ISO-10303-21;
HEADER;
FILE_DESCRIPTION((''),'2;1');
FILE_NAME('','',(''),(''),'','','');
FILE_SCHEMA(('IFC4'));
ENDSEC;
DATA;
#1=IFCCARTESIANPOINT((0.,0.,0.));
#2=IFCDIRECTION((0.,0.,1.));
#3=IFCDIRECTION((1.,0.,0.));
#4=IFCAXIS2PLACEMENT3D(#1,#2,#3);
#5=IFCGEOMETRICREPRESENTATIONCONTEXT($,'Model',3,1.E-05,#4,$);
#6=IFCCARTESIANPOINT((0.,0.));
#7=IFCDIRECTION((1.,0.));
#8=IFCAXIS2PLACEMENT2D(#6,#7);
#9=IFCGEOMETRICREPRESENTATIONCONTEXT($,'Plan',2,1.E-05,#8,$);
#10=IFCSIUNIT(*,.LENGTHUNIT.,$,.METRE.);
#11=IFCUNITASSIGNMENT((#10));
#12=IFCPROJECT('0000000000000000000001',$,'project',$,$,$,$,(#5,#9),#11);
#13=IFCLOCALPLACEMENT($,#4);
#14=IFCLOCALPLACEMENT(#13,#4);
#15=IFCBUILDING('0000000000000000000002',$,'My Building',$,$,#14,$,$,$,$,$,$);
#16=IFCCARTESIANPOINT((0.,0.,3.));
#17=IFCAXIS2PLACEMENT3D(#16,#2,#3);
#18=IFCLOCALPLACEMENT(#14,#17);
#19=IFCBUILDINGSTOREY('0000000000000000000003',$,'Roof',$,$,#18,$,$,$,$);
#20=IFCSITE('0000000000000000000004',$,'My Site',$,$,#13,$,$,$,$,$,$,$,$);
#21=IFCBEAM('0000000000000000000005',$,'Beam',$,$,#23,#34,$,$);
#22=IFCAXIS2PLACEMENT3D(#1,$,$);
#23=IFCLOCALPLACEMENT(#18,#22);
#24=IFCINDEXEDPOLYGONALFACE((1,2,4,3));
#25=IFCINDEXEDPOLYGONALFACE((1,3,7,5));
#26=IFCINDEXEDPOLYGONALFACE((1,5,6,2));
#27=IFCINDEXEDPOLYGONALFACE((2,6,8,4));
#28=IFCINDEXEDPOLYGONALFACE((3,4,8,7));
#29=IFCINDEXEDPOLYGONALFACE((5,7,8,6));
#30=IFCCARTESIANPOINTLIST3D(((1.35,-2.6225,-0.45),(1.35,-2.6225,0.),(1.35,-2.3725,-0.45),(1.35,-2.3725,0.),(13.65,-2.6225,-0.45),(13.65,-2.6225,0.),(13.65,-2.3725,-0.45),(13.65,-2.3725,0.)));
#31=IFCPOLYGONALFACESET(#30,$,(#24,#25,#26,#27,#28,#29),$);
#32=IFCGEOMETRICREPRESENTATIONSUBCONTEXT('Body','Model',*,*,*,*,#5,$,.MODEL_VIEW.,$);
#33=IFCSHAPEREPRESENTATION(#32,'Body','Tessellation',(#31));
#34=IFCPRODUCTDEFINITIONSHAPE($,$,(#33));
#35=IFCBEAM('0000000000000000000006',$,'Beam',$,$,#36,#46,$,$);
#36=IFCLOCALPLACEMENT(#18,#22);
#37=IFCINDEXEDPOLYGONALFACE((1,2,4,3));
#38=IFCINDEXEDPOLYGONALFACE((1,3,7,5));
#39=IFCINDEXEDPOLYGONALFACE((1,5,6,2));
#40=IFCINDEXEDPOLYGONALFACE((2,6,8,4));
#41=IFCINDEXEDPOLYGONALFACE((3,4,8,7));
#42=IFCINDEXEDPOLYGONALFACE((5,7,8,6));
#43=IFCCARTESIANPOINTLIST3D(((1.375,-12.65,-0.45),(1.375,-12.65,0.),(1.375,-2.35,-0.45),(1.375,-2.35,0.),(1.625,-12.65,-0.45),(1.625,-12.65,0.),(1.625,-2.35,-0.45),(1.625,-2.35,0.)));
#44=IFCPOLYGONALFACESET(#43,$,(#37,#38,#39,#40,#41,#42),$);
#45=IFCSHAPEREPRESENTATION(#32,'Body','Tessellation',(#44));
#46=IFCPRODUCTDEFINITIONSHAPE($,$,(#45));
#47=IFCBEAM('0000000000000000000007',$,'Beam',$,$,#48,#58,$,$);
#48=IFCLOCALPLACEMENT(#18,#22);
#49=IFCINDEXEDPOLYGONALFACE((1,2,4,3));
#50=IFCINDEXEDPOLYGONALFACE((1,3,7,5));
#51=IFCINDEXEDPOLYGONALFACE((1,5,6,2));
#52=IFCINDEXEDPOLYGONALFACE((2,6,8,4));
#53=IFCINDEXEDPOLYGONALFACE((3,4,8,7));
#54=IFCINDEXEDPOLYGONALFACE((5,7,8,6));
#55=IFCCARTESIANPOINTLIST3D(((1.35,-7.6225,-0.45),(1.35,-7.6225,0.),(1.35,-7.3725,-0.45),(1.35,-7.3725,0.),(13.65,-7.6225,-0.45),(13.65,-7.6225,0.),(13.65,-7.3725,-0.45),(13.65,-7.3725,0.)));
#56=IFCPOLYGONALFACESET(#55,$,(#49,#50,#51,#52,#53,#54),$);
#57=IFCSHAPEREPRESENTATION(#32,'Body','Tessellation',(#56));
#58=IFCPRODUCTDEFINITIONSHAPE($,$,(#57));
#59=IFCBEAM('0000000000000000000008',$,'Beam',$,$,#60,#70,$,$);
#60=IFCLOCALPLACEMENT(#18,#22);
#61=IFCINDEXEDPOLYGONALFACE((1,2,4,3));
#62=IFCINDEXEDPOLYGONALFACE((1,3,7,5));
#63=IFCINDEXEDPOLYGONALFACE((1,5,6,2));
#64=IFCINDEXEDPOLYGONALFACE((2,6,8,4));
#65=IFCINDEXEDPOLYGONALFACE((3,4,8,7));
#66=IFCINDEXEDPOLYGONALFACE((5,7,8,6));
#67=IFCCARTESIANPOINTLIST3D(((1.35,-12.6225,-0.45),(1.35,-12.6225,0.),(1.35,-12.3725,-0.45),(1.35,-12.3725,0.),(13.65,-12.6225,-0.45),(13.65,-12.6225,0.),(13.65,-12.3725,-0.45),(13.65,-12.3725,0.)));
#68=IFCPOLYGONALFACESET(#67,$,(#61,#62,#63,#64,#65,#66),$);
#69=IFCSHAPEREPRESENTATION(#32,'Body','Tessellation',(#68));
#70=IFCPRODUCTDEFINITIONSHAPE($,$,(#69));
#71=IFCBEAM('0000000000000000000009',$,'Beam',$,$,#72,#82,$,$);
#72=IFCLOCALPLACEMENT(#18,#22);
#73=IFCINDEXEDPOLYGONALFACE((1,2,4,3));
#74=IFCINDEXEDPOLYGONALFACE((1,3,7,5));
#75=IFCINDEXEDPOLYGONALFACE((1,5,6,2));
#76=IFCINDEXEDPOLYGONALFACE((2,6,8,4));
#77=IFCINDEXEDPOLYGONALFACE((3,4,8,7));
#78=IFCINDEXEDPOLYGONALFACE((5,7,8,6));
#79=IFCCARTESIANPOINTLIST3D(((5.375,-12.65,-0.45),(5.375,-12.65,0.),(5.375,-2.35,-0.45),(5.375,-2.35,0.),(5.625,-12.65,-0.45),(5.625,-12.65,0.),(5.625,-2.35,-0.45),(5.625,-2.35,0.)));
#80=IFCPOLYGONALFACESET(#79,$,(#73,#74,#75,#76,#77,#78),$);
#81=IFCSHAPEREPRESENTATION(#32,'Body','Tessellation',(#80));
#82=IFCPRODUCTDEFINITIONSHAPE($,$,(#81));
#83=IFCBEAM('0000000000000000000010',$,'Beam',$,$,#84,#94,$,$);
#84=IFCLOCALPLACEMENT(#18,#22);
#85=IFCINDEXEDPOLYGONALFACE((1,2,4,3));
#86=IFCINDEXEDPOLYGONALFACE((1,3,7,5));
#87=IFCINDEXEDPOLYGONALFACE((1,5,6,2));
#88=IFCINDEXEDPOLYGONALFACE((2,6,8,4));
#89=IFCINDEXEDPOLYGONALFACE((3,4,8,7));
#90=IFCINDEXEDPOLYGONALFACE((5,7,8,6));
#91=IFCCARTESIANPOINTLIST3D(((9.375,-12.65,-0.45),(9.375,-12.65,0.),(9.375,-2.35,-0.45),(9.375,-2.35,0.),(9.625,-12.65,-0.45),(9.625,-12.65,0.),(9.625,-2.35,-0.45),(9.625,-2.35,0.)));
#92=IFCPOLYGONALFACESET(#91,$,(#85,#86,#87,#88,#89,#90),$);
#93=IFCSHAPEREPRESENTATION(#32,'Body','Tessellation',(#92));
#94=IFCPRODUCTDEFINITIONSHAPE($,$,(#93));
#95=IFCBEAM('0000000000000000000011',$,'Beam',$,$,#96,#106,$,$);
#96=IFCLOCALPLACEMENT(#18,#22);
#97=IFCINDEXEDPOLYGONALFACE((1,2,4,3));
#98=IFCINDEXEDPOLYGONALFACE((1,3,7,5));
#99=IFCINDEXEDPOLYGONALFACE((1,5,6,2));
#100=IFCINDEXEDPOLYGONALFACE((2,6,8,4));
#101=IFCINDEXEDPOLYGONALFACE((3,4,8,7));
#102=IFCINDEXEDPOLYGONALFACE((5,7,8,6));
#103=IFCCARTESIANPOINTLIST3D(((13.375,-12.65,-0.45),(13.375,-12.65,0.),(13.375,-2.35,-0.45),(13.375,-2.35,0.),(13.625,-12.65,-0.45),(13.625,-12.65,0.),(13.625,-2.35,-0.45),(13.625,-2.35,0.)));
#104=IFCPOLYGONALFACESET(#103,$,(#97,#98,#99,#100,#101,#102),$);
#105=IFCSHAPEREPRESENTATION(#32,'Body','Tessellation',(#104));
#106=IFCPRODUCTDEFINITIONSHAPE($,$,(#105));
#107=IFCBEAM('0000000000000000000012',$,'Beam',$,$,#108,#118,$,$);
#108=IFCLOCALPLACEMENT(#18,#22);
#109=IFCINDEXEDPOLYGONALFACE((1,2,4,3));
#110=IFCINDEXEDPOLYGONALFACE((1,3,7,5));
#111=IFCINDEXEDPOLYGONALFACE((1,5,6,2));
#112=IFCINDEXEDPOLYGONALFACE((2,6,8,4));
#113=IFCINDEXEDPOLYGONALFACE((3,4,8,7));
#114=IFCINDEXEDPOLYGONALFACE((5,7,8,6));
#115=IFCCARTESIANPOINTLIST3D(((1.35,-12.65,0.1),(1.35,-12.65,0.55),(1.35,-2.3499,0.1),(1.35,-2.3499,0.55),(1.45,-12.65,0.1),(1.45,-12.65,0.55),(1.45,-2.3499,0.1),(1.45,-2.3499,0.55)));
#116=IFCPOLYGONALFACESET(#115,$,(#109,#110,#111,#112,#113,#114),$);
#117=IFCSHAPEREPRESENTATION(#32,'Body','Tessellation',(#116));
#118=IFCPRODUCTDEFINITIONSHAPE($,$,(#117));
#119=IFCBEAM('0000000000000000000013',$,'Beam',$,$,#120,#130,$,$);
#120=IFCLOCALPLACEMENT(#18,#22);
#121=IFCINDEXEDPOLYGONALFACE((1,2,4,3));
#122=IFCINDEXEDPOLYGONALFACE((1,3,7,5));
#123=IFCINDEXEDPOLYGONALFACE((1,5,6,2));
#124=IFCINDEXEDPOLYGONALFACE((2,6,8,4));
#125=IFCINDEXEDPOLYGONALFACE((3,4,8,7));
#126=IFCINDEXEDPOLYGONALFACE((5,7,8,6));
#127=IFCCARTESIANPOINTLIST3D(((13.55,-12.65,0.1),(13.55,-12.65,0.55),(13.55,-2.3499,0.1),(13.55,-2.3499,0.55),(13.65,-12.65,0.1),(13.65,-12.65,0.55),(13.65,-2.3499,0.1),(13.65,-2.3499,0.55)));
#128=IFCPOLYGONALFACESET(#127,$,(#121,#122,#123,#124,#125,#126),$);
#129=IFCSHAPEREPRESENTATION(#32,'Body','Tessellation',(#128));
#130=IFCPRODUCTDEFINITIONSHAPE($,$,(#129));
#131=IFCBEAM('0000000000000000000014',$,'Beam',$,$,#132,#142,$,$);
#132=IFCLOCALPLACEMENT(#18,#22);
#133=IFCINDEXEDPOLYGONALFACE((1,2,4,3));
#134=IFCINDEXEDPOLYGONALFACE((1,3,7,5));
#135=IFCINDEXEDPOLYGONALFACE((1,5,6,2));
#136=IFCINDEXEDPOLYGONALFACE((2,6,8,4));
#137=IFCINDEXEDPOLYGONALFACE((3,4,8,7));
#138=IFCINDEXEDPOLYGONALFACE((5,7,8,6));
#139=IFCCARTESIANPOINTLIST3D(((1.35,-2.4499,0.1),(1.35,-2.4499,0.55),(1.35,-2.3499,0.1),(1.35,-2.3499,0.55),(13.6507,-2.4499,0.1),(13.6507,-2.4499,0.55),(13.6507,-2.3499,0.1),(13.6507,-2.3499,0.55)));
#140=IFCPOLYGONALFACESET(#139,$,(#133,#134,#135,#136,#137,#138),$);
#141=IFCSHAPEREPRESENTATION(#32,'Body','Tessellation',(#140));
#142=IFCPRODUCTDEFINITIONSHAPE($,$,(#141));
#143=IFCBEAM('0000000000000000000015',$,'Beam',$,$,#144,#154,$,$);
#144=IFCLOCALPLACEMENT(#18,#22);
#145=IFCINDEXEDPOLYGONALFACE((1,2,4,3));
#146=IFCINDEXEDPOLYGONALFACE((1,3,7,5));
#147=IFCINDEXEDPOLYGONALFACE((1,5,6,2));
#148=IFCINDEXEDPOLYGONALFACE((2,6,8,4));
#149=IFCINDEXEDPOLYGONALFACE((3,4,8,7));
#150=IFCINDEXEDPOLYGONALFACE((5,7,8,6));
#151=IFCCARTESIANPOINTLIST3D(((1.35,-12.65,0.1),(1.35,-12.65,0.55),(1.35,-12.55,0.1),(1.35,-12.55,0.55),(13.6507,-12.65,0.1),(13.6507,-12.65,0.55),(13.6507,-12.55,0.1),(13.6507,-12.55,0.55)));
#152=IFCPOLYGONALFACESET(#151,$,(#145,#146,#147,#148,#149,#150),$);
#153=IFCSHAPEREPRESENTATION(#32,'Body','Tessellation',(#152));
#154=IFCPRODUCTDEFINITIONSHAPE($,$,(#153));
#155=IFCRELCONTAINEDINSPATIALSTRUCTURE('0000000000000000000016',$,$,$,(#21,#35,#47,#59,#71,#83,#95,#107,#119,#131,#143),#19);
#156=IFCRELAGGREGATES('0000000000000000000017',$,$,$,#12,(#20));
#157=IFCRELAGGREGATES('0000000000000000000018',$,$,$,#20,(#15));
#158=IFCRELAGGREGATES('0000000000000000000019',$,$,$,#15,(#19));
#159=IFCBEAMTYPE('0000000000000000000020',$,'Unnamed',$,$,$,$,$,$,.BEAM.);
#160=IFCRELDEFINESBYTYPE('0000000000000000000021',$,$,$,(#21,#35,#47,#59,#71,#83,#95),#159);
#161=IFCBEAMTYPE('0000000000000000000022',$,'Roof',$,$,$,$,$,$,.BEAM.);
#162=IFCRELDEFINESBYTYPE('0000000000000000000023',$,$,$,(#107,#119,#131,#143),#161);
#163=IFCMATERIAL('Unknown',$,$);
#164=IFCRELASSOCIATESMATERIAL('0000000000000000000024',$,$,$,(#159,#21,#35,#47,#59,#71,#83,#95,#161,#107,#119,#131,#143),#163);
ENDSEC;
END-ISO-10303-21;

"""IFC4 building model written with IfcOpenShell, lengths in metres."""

from ifc_helpers import new_model, si_unit, frame, origin_with_axes, origin_2d_with_axis, place, context, subcontext, project, spatial, rectangle, extrude, material, material_profile, profile_set, profile_usage, type_object, element, save


model = new_model("IFC4")

# Units and contexts
model_context = context("Model", 3, precision=1e-05, world=origin_with_axes())
plan_context = context("Plan", 2, precision=1e-05, world=origin_2d_with_axis())
body_context = subcontext(model_context, "Body", "Model", "MODEL_VIEW")
ifc_project = project(units=[si_unit("LENGTHUNIT", "METRE")], contexts=[model_context, plan_context])

# Site, building, storey
site_placement = place(None, origin_with_axes())
site = spatial("IfcSite", under=ifc_project, at=site_placement, Name="My Site")
building_placement = place(site_placement, origin_with_axes())
building = spatial("IfcBuilding", under=site, at=building_placement, Name="My Building")
storey_placement = place(building_placement, frame((0.0, 0.0, 3.0), z_axis=(0.0, 0.0, 1.0), x_axis=(1.0, 0.0, 0.0)))
storey = spatial("IfcBuildingStorey", under=building, at=storey_placement, Name="Roof")

# Beams
ifc_material = material(Name="Unknown")
ifc_material_profile_1 = material_profile(ifc_material, rectangle(XDim=0.25, YDim=0.45))
ifc_profile_set_1 = profile_set([ifc_material_profile_1])
ifc_profile_usage_1 = profile_usage(ifc_profile_set_1, cardinal=5)
beam_type_1 = type_object("IfcBeamType", Name="Unnamed", PredefinedType="BEAM", material=ifc_profile_set_1)
beam_1_placement = place(storey_placement, frame((1.35, -2.4975, -0.225), z_axis=(1.0, 0.0, 0.0), x_axis=(0.0, 1.0, 0.0)))
element("IfcBeam", 1, at=beam_1_placement, inside=storey, type_object=beam_type_1, material=ifc_profile_usage_1, Name="Beam", context=body_context, shape_type="SweptSolid", body=[
    extrude(rectangle(XDim=0.25, YDim=0.45), origin_with_axes(), (0.0, 0.0, 1.0), 12.3),
])
ifc_profile_usage_2 = profile_usage(ifc_profile_set_1, cardinal=4)
beam_2_placement = place(storey_placement, frame((1.625, -2.35, -0.225), z_axis=(0.0, -1.0, 0.0), x_axis=(1.0, 0.0, 0.0)))
element("IfcBeam", 2, at=beam_2_placement, inside=storey, type_object=beam_type_1, material=ifc_profile_usage_2, Name="Beam", context=body_context, shape_type="SweptSolid", body=[
    extrude(rectangle(XDim=0.25, YDim=0.45), frame((-0.125, 0.0, 0.0), z_axis=(0.0, 0.0, 1.0), x_axis=(1.0, 0.0, 0.0)), (0.0, 0.0, 1.0), 10.3),
])
ifc_profile_usage_3 = profile_usage(ifc_profile_set_1, cardinal=5)
beam_3_placement = place(storey_placement, frame((1.35, -7.4975, -0.225), z_axis=(1.0, 0.0, 0.0), x_axis=(0.0, 1.0, 0.0)))
element("IfcBeam", 3, at=beam_3_placement, inside=storey, type_object=beam_type_1, material=ifc_profile_usage_3, Name="Beam", context=body_context, shape_type="SweptSolid", body=[
    extrude(rectangle(XDim=0.25, YDim=0.45), origin_with_axes(), (0.0, 0.0, 1.0), 12.3),
])
ifc_profile_usage_4 = profile_usage(ifc_profile_set_1, cardinal=5)
beam_4_placement = place(storey_placement, frame((1.35, -12.4975, -0.225), z_axis=(1.0, 0.0, 0.0), x_axis=(0.0, 1.0, 0.0)))
element("IfcBeam", 4, at=beam_4_placement, inside=storey, type_object=beam_type_1, material=ifc_profile_usage_4, Name="Beam", context=body_context, shape_type="SweptSolid", body=[
    extrude(rectangle(XDim=0.25, YDim=0.45), origin_with_axes(), (0.0, 0.0, 1.0), 12.3),
])
ifc_profile_usage_5 = profile_usage(ifc_profile_set_1, cardinal=4)
beam_5_placement = place(storey_placement, frame((5.625, -2.35, -0.225), z_axis=(0.0, -1.0, 0.0), x_axis=(1.0, 0.0, 0.0)))
element("IfcBeam", 5, at=beam_5_placement, inside=storey, type_object=beam_type_1, material=ifc_profile_usage_5, Name="Beam", context=body_context, shape_type="SweptSolid", body=[
    extrude(rectangle(XDim=0.25, YDim=0.45), frame((-0.125, 0.0, 0.0), z_axis=(0.0, 0.0, 1.0), x_axis=(1.0, 0.0, 0.0)), (0.0, 0.0, 1.0), 10.3),
])
ifc_profile_usage_6 = profile_usage(ifc_profile_set_1, cardinal=4)
beam_6_placement = place(storey_placement, frame((9.625, -2.35, -0.225), z_axis=(0.0, -1.0, 0.0), x_axis=(1.0, 0.0, 0.0)))
element("IfcBeam", 6, at=beam_6_placement, inside=storey, type_object=beam_type_1, material=ifc_profile_usage_6, Name="Beam", context=body_context, shape_type="SweptSolid", body=[
    extrude(rectangle(XDim=0.25, YDim=0.45), frame((-0.125, 0.0, 0.0), z_axis=(0.0, 0.0, 1.0), x_axis=(1.0, 0.0, 0.0)), (0.0, 0.0, 1.0), 10.3),
])
ifc_profile_usage_7 = profile_usage(ifc_profile_set_1, cardinal=4)
beam_7_placement = place(storey_placement, frame((13.625, -2.35, -0.225), z_axis=(0.0, -1.0, 0.0), x_axis=(1.0, 0.0, 0.0)))
element("IfcBeam", 7, at=beam_7_placement, inside=storey, type_object=beam_type_1, material=ifc_profile_usage_7, Name="Beam", context=body_context, shape_type="SweptSolid", body=[
    extrude(rectangle(XDim=0.25, YDim=0.45), frame((-0.125, 0.0, 0.0), z_axis=(0.0, 0.0, 1.0), x_axis=(1.0, 0.0, 0.0)), (0.0, 0.0, 1.0), 10.3),
])
ifc_material_profile_2 = material_profile(ifc_material, rectangle(XDim=0.1, YDim=0.45))
ifc_profile_set_2 = profile_set([ifc_material_profile_2])
ifc_profile_usage_8 = profile_usage(ifc_profile_set_2, cardinal=4)
beam_type_2 = type_object("IfcBeamType", Name="Roof", PredefinedType="BEAM", material=ifc_profile_set_2)
beam_8_placement = place(storey_placement, frame((1.45, -2.3499, 0.325), z_axis=(0.0, -1.0, 0.0), x_axis=(1.0, 0.0, 0.0)))
element("IfcBeam", 8, at=beam_8_placement, inside=storey, type_object=beam_type_2, material=ifc_profile_usage_8, Name="Beam", context=body_context, shape_type="SweptSolid", body=[
    extrude(rectangle(XDim=0.1, YDim=0.45), frame((-0.05, 0.0, 0.0), z_axis=(0.0, 0.0, 1.0), x_axis=(1.0, 0.0, 0.0)), (0.0, 0.0, 1.0), 10.3001),
])
ifc_profile_usage_9 = profile_usage(ifc_profile_set_2, cardinal=4)
beam_9_placement = place(storey_placement, frame((13.65, -2.3499, 0.325), z_axis=(0.0, -1.0, 0.0), x_axis=(1.0, 0.0, 0.0)))
element("IfcBeam", 9, at=beam_9_placement, inside=storey, type_object=beam_type_2, material=ifc_profile_usage_9, Name="Beam", context=body_context, shape_type="SweptSolid", body=[
    extrude(rectangle(XDim=0.1, YDim=0.45), frame((-0.05, 0.0, 0.0), z_axis=(0.0, 0.0, 1.0), x_axis=(1.0, 0.0, 0.0)), (0.0, 0.0, 1.0), 10.3001),
])
ifc_profile_usage_10 = profile_usage(ifc_profile_set_2, cardinal=4)
beam_10_placement = place(storey_placement, frame((1.35, -2.3499, 0.325), z_axis=(1.0, -0.000001, 0.000001), x_axis=(0.000001, 1.0, 0.0)))
element("IfcBeam", 10, at=beam_10_placement, inside=storey, type_object=beam_type_2, material=ifc_profile_usage_10, Name="Beam", context=body_context, shape_type="SweptSolid", body=[
    extrude(rectangle(XDim=0.1, YDim=0.45), frame((-0.05, 0.0, 0.0), z_axis=(0.0, 0.0, 1.0), x_axis=(1.0, 0.0, 0.0)), (0.0, 0.0, 1.0), 12.3007),
])
ifc_profile_usage_11 = profile_usage(ifc_profile_set_2, cardinal=4)
beam_11_placement = place(storey_placement, frame((1.35, -12.55, 0.325), z_axis=(1.0, -0.000001, 0.000001), x_axis=(0.000001, 1.0, 0.0)))
element("IfcBeam", 11, at=beam_11_placement, inside=storey, type_object=beam_type_2, material=ifc_profile_usage_11, Name="Beam", context=body_context, shape_type="SweptSolid", body=[
    extrude(rectangle(XDim=0.1, YDim=0.45), frame((-0.05, 0.0, 0.0), z_axis=(0.0, 0.0, 1.0), x_axis=(1.0, 0.0, 0.0)), (0.0, 0.0, 1.0), 12.3007),
])

save(model, "model.ifc")
